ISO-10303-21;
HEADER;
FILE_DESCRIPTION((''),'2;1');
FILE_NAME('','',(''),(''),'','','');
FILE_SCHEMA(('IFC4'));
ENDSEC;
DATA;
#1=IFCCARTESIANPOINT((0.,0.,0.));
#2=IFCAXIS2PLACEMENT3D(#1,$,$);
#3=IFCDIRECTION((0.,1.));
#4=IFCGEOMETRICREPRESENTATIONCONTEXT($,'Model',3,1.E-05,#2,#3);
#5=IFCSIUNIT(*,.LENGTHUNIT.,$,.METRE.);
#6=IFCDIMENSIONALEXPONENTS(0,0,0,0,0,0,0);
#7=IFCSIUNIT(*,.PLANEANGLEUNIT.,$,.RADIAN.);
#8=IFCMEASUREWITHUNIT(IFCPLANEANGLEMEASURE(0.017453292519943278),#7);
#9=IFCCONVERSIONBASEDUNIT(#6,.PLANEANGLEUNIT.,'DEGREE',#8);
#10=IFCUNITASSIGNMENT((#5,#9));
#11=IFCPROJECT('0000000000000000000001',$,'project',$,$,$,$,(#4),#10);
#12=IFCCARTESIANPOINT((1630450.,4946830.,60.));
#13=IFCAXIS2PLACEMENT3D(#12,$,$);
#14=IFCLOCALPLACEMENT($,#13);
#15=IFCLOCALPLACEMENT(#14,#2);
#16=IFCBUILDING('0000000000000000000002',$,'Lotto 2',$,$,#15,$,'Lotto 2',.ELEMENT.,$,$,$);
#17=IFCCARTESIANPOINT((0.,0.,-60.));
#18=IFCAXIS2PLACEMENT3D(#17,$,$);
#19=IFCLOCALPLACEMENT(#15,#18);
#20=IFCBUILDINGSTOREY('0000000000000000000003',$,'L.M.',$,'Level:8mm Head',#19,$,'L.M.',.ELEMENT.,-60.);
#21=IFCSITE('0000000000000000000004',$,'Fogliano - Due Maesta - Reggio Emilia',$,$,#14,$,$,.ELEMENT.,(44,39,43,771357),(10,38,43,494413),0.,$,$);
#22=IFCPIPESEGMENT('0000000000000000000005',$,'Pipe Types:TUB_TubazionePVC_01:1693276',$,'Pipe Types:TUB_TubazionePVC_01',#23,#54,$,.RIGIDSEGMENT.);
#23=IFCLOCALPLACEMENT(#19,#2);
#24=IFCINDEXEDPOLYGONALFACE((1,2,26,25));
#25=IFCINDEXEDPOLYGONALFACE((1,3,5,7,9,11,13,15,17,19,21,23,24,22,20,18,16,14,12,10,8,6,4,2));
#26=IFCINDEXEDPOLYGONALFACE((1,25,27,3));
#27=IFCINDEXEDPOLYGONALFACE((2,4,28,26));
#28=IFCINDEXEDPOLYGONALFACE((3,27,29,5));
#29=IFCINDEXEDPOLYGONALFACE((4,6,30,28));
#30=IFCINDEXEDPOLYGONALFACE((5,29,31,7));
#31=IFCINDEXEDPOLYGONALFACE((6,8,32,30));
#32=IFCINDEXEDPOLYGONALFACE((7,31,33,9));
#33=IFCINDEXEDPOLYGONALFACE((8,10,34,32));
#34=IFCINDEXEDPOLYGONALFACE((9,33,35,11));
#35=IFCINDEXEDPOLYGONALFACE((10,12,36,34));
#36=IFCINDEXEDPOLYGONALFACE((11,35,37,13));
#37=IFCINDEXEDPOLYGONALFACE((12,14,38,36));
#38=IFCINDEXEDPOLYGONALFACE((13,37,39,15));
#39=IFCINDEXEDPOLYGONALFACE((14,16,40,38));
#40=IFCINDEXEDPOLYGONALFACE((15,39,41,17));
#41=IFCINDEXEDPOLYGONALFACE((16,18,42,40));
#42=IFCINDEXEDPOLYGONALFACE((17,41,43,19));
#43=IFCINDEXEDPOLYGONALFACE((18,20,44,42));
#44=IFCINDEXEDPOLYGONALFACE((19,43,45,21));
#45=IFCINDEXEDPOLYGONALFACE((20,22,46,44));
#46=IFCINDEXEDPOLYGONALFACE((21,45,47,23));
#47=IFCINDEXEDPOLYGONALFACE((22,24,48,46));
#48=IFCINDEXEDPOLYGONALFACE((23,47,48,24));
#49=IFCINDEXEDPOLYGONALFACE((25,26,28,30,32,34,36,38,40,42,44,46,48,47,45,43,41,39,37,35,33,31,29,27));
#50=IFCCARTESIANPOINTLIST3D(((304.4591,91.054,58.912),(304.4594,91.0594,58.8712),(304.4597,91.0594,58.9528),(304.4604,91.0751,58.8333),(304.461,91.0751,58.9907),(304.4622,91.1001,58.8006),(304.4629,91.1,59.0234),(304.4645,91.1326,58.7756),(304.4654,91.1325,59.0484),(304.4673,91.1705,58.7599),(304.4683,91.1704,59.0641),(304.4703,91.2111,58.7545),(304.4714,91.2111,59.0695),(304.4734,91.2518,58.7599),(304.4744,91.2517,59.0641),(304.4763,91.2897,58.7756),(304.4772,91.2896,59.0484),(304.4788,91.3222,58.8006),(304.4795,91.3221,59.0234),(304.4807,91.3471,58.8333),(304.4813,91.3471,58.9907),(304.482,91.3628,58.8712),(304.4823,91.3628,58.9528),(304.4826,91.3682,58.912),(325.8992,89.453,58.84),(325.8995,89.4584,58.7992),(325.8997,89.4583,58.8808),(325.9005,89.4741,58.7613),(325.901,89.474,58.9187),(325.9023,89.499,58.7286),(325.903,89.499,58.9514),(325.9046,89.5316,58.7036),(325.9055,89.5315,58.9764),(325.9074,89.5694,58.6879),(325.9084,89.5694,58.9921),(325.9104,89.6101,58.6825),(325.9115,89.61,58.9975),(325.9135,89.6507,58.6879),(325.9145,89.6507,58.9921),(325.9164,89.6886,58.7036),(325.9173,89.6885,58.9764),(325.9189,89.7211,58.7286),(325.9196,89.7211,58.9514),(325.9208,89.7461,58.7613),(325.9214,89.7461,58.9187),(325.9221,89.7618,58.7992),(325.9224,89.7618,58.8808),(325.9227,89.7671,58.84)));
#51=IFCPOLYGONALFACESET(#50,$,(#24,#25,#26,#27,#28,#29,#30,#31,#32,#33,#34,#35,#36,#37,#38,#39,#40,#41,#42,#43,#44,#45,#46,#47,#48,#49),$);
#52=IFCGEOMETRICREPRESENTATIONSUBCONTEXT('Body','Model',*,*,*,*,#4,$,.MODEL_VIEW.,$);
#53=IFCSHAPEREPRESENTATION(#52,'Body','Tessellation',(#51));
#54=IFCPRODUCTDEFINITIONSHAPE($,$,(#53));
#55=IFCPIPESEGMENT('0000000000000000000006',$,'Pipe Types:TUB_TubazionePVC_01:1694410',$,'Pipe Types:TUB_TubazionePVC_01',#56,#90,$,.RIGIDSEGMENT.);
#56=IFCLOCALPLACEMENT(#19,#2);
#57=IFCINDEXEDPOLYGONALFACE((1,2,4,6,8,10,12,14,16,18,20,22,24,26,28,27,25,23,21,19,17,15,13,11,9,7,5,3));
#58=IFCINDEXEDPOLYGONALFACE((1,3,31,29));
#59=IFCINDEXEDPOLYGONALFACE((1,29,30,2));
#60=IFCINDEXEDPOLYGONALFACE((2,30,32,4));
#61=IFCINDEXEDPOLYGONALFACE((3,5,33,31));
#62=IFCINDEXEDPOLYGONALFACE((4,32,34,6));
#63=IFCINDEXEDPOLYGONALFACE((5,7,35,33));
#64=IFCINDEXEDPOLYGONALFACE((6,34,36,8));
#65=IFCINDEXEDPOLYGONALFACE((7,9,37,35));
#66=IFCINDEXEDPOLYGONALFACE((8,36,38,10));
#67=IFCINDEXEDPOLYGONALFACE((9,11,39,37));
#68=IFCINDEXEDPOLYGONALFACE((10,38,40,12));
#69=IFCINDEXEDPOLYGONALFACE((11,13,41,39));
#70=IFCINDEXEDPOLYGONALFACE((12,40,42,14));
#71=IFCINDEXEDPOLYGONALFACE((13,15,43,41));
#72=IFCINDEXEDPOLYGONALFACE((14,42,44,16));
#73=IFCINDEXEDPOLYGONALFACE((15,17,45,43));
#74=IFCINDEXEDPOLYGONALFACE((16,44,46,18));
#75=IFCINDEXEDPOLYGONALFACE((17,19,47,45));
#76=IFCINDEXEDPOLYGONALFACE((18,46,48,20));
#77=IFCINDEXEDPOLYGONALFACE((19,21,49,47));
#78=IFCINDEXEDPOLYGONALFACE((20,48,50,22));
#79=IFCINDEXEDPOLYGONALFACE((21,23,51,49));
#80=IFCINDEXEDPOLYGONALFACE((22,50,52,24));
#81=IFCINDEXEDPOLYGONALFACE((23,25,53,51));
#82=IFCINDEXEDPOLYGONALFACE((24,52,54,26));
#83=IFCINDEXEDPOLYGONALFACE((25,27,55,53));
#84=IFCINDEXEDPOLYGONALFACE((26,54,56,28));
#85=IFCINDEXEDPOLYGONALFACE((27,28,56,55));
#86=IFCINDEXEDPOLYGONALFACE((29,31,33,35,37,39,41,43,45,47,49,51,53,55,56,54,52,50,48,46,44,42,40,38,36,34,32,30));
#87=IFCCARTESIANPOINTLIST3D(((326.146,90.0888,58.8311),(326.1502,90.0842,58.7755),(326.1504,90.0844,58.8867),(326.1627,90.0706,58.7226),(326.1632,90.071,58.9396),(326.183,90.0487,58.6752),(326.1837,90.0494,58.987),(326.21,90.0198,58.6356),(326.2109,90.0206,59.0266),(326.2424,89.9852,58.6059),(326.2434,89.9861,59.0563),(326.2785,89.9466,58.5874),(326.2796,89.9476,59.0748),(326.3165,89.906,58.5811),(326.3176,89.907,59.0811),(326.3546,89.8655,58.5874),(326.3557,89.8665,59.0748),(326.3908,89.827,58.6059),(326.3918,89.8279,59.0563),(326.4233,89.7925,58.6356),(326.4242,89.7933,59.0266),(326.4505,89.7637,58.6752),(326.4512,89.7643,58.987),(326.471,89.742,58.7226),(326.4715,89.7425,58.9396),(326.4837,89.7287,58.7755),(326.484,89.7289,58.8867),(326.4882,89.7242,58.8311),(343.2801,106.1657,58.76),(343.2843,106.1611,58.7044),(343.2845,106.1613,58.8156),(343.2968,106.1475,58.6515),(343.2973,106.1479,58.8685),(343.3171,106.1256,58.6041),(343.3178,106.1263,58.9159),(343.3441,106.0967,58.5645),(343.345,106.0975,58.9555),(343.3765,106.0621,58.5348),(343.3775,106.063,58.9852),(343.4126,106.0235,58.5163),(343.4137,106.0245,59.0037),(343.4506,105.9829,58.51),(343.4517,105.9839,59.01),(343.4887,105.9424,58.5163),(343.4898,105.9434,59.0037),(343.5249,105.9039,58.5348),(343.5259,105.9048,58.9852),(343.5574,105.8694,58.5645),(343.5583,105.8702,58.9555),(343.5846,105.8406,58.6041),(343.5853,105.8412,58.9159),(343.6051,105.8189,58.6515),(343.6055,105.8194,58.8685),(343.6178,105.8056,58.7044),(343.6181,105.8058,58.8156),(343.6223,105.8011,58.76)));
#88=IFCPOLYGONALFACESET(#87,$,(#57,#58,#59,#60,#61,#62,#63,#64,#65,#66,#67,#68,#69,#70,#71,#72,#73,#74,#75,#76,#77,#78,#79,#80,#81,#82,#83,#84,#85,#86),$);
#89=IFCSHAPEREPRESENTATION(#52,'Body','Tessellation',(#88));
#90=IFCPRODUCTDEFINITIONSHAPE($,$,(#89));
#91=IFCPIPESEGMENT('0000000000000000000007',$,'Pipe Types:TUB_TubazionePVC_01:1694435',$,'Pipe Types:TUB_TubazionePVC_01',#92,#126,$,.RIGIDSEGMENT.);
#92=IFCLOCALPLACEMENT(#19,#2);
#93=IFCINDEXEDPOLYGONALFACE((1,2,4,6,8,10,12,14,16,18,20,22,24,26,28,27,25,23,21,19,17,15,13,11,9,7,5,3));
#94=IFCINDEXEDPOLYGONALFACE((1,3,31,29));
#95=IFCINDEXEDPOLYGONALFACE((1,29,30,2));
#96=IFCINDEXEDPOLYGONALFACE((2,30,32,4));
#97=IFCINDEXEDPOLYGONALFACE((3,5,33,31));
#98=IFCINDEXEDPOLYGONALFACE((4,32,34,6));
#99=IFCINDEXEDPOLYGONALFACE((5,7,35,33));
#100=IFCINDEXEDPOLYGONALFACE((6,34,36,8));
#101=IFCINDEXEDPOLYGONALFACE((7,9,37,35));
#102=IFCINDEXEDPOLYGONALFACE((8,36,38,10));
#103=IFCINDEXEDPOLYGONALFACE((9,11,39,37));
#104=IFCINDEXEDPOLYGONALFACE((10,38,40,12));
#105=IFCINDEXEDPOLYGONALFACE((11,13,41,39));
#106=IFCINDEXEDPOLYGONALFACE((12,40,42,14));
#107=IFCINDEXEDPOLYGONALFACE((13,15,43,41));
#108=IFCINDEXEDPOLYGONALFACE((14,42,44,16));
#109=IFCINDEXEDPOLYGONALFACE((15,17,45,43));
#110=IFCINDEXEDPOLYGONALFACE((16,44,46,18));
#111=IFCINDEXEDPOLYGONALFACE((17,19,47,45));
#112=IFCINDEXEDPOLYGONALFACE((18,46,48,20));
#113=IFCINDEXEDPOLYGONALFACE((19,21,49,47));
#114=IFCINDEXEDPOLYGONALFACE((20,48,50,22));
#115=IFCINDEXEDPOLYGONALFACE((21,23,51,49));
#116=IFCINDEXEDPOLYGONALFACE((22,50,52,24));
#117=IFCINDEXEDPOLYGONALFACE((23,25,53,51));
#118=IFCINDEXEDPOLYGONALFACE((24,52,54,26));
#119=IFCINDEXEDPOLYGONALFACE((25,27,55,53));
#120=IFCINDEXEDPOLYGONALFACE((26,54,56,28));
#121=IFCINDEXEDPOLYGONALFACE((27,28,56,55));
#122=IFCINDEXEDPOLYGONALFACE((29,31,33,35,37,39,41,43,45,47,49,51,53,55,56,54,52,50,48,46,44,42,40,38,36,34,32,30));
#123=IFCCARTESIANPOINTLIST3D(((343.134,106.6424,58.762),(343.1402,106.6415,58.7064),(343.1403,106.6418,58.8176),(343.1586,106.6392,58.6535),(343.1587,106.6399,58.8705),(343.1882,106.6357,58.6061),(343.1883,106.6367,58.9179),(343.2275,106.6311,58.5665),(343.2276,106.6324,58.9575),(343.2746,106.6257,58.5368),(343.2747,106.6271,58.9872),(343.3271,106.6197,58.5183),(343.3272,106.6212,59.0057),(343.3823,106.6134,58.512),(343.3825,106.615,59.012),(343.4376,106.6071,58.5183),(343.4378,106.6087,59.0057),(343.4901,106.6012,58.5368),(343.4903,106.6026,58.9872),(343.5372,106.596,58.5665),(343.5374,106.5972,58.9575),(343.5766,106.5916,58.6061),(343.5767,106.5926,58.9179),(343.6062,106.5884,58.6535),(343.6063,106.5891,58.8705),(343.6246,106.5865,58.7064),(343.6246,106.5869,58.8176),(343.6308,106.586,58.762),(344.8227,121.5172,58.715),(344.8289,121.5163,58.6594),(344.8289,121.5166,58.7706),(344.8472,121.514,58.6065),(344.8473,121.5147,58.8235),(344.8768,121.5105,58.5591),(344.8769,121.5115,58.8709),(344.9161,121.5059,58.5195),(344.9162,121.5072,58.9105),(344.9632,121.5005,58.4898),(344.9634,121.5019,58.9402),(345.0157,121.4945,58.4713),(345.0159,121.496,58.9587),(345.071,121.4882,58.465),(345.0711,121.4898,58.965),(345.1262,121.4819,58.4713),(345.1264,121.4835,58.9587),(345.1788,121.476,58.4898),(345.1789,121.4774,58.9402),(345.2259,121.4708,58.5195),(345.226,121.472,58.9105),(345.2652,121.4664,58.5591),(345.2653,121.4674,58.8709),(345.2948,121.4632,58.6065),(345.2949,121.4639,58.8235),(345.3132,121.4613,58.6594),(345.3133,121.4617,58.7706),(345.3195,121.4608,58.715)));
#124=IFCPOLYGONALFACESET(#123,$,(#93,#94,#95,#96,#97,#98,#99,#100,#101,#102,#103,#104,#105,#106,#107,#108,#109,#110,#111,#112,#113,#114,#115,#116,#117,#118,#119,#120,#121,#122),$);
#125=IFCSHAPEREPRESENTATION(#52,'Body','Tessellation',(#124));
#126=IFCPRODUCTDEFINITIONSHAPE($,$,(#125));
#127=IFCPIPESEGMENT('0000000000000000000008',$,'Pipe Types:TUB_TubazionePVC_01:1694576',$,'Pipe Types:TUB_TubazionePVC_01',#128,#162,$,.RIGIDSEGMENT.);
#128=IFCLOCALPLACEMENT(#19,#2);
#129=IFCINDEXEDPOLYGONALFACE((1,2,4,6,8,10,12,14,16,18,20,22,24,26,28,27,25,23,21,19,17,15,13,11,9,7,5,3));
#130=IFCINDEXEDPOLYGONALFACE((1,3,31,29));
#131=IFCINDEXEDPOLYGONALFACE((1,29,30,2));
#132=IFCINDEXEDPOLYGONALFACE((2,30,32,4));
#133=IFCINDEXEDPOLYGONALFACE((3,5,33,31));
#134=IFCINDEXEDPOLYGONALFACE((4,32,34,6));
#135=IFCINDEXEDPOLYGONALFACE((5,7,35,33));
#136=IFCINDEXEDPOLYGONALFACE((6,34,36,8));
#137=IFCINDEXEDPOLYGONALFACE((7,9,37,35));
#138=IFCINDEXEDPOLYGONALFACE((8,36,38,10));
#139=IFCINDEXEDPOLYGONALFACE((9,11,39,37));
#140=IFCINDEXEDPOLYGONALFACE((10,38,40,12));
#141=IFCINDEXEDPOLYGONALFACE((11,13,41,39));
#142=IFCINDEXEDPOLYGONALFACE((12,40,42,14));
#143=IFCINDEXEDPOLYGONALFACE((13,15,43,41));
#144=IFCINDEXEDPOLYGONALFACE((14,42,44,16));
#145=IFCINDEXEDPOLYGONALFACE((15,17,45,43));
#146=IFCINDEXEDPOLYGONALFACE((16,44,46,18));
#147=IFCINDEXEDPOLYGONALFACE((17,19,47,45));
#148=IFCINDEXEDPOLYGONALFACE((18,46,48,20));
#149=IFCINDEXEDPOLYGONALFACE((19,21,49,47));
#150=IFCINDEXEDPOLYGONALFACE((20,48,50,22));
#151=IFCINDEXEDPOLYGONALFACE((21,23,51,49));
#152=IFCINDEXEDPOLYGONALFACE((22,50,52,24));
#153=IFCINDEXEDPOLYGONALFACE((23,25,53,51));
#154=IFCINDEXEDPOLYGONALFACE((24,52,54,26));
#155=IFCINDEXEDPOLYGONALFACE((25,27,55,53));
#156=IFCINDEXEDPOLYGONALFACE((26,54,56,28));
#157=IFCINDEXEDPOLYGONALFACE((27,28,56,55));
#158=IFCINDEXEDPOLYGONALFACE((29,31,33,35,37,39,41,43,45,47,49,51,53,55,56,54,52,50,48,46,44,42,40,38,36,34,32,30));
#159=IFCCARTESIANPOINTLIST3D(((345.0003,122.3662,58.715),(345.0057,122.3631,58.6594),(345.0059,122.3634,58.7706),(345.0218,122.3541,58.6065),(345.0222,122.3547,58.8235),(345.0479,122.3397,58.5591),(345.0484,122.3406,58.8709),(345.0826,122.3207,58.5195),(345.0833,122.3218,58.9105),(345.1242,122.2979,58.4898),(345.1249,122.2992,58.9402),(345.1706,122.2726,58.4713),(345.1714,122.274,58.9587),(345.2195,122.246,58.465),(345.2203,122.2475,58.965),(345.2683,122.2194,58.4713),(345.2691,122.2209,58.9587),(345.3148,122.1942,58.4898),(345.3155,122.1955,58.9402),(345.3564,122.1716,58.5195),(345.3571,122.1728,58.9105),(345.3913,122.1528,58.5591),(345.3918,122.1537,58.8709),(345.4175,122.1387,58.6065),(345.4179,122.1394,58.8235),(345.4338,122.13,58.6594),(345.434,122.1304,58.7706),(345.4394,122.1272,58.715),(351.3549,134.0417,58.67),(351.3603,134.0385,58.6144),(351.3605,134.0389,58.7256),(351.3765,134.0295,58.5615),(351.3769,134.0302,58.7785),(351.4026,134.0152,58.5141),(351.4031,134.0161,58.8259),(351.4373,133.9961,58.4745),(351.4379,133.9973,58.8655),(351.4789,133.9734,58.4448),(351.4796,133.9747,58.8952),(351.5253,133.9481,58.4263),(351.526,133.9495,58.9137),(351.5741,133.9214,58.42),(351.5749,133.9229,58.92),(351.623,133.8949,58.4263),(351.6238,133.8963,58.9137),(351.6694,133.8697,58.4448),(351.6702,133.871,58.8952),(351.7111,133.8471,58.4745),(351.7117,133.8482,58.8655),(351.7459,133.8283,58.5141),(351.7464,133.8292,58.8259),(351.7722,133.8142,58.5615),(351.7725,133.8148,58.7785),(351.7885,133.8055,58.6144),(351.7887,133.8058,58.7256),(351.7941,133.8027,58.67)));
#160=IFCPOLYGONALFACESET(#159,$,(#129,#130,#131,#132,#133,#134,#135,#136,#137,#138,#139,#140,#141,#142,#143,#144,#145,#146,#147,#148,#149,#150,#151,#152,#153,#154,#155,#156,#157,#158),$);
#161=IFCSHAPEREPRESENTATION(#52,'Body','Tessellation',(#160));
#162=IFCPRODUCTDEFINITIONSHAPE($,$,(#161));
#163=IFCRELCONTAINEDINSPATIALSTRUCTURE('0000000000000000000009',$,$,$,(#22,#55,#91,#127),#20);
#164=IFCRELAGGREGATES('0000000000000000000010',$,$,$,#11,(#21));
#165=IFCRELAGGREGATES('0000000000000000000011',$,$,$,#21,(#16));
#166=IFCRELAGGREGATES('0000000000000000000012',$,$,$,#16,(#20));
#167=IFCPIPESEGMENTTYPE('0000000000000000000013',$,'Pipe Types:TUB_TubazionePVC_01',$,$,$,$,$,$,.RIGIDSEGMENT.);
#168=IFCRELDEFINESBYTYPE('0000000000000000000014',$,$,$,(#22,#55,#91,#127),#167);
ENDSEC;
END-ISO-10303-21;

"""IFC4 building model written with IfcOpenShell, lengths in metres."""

from ifc_helpers import new_model, entity, si_unit, converted_unit, direction, frame, origin, place, context, subcontext, project, spatial, arc, indexed_curve, outline, extrude, type_object, element, save


model = new_model("IFC4")

# Units and contexts
model_context = context("Model", 3, precision=1e-05, world=origin(), true_north=direction((0.0, 1.0)))
body_context = subcontext(model_context, "Body", "Model", "MODEL_VIEW")
ifc_project = project(units=[si_unit("LENGTHUNIT", "METRE"), converted_unit("PLANEANGLEUNIT", "DEGREE", entity("IfcPlaneAngleMeasure", 0.017453292519943278), si_unit("PLANEANGLEUNIT", "RADIAN"), dimensions=[0, 0, 0, 0, 0, 0, 0])], contexts=[model_context])

# Site, building, storey
site_placement = place(None, frame((1630450.0, 4946830.0, 60.0)))
site = spatial("IfcSite", under=ifc_project, at=site_placement, Name="Fogliano - Due Maesta - Reggio Emilia", CompositionType="ELEMENT", RefLatitude=(44, 39, 43, 771357), RefLongitude=(10, 38, 43, 494413), RefElevation=0.0)
building_placement = place(site_placement, origin())
building = spatial("IfcBuilding", under=site, at=building_placement, Name="Lotto 2", LongName="Lotto 2", CompositionType="ELEMENT")
storey_placement = place(building_placement, frame((0.0, 0.0, -60.0)))
storey = spatial("IfcBuildingStorey", under=building, at=storey_placement, Name="L.M.", ObjectType="Level:8mm Head", LongName="L.M.", CompositionType="ELEMENT", Elevation=-60.0)

# Pipe segments
pipe_segment_type = type_object("IfcPipeSegmentType", Name="Pipe Types:TUB_TubazionePVC_01", PredefinedType="RIGIDSEGMENT")
pipe_segment_1_placement = place(storey_placement, origin())
element("IfcPipeSegment", 1, at=pipe_segment_1_placement, inside=storey, type_object=pipe_segment_type, Name="Pipe Types:TUB_TubazionePVC_01:1693276", ObjectType="Pipe Types:TUB_TubazionePVC_01", PredefinedType="RIGIDSEGMENT", context=body_context, shape_type="SweptSolid", body=[
    extrude(outline(indexed_curve([(0.1575, 0.0), (0.1114, 0.1114), (0.0, 0.1575), (-0.1114, 0.1114), (-0.1575, 0.0), (-0.1114, -0.1114), (0.0, -0.1575), (0.1114, -0.1114)], segments=[arc(1, 2, 3), arc(3, 4, 5), arc(5, 6, 7), arc(7, 8, 1)], self_intersect=False)), frame((304.4709, 91.2111, 58.912), z_axis=(0.997218, -0.074468, -0.003349), x_axis=(-0.074468, -0.997223, 0.0)), (0.0, 0.0, 1.0), 21.4999),
])
pipe_segment_2_placement = place(storey_placement, origin())
element("IfcPipeSegment", 2, at=pipe_segment_2_placement, inside=storey, type_object=pipe_segment_type, Name="Pipe Types:TUB_TubazionePVC_01:1694410", ObjectType="Pipe Types:TUB_TubazionePVC_01", PredefinedType="RIGIDSEGMENT", context=body_context, shape_type="SweptSolid", body=[
    extrude(outline(indexed_curve([(0.25, 0.0), (0.1768, 0.1768), (0.0, 0.25), (-0.1768, 0.1768), (-0.25, 0.0), (-0.1768, -0.1768), (0.0, -0.25), (0.1768, -0.1768)], segments=[arc(1, 2, 3), arc(3, 4, 5), arc(5, 6, 7), arc(7, 8, 1)], self_intersect=False)), frame((343.4512, 105.9834, 58.76), z_axis=(-0.729243, -0.684248, 0.003026), x_axis=(0.684251, -0.729247, 0.0)), (0.0, 0.0, 1.0), 23.4957),
])
pipe_segment_3_placement = place(storey_placement, origin())
element("IfcPipeSegment", 3, at=pipe_segment_3_placement, inside=storey, type_object=pipe_segment_type, Name="Pipe Types:TUB_TubazionePVC_01:1694435", ObjectType="Pipe Types:TUB_TubazionePVC_01", PredefinedType="RIGIDSEGMENT", context=body_context, shape_type="SweptSolid", body=[
    extrude(outline(indexed_curve([(0.25, 0.0), (0.1768, 0.1768), (0.0, 0.25), (-0.1768, 0.1768), (-0.25, 0.0), (-0.1768, -0.1768), (0.0, -0.25), (0.1768, -0.1768)], segments=[arc(1, 2, 3), arc(3, 4, 5), arc(5, 6, 7), arc(7, 8, 1)], self_intersect=False)), frame((343.3824, 106.6142, 58.762), z_axis=(0.112798, 0.993613, -0.00314), x_axis=(0.993618, -0.112799, 0.0)), (0.0, 0.0, 1.0), 14.9704),
])
pipe_segment_4_placement = place(storey_placement, origin())
element("IfcPipeSegment", 4, at=pipe_segment_4_placement, inside=storey, type_object=pipe_segment_type, Name="Pipe Types:TUB_TubazionePVC_01:1694576", ObjectType="Pipe Types:TUB_TubazionePVC_01", PredefinedType="RIGIDSEGMENT", context=body_context, shape_type="SweptSolid", body=[
    extrude(outline(indexed_curve([(0.25, 0.0), (0.1768, 0.1768), (0.0, 0.25), (-0.1768, 0.1768), (-0.25, 0.0), (-0.1768, -0.1768), (0.0, -0.25), (0.1768, -0.1768)], segments=[arc(1, 2, 3), arc(3, 4, 5), arc(5, 6, 7), arc(7, 8, 1)], self_intersect=False)), frame((351.5745, 133.9222, 58.67), z_axis=(-0.478051, -0.878326, 0.003385), x_axis=(0.878331, -0.478053, 0.0)), (0.0, 0.0, 1.0), 13.2929),
])

save(model, "model.ifc")
